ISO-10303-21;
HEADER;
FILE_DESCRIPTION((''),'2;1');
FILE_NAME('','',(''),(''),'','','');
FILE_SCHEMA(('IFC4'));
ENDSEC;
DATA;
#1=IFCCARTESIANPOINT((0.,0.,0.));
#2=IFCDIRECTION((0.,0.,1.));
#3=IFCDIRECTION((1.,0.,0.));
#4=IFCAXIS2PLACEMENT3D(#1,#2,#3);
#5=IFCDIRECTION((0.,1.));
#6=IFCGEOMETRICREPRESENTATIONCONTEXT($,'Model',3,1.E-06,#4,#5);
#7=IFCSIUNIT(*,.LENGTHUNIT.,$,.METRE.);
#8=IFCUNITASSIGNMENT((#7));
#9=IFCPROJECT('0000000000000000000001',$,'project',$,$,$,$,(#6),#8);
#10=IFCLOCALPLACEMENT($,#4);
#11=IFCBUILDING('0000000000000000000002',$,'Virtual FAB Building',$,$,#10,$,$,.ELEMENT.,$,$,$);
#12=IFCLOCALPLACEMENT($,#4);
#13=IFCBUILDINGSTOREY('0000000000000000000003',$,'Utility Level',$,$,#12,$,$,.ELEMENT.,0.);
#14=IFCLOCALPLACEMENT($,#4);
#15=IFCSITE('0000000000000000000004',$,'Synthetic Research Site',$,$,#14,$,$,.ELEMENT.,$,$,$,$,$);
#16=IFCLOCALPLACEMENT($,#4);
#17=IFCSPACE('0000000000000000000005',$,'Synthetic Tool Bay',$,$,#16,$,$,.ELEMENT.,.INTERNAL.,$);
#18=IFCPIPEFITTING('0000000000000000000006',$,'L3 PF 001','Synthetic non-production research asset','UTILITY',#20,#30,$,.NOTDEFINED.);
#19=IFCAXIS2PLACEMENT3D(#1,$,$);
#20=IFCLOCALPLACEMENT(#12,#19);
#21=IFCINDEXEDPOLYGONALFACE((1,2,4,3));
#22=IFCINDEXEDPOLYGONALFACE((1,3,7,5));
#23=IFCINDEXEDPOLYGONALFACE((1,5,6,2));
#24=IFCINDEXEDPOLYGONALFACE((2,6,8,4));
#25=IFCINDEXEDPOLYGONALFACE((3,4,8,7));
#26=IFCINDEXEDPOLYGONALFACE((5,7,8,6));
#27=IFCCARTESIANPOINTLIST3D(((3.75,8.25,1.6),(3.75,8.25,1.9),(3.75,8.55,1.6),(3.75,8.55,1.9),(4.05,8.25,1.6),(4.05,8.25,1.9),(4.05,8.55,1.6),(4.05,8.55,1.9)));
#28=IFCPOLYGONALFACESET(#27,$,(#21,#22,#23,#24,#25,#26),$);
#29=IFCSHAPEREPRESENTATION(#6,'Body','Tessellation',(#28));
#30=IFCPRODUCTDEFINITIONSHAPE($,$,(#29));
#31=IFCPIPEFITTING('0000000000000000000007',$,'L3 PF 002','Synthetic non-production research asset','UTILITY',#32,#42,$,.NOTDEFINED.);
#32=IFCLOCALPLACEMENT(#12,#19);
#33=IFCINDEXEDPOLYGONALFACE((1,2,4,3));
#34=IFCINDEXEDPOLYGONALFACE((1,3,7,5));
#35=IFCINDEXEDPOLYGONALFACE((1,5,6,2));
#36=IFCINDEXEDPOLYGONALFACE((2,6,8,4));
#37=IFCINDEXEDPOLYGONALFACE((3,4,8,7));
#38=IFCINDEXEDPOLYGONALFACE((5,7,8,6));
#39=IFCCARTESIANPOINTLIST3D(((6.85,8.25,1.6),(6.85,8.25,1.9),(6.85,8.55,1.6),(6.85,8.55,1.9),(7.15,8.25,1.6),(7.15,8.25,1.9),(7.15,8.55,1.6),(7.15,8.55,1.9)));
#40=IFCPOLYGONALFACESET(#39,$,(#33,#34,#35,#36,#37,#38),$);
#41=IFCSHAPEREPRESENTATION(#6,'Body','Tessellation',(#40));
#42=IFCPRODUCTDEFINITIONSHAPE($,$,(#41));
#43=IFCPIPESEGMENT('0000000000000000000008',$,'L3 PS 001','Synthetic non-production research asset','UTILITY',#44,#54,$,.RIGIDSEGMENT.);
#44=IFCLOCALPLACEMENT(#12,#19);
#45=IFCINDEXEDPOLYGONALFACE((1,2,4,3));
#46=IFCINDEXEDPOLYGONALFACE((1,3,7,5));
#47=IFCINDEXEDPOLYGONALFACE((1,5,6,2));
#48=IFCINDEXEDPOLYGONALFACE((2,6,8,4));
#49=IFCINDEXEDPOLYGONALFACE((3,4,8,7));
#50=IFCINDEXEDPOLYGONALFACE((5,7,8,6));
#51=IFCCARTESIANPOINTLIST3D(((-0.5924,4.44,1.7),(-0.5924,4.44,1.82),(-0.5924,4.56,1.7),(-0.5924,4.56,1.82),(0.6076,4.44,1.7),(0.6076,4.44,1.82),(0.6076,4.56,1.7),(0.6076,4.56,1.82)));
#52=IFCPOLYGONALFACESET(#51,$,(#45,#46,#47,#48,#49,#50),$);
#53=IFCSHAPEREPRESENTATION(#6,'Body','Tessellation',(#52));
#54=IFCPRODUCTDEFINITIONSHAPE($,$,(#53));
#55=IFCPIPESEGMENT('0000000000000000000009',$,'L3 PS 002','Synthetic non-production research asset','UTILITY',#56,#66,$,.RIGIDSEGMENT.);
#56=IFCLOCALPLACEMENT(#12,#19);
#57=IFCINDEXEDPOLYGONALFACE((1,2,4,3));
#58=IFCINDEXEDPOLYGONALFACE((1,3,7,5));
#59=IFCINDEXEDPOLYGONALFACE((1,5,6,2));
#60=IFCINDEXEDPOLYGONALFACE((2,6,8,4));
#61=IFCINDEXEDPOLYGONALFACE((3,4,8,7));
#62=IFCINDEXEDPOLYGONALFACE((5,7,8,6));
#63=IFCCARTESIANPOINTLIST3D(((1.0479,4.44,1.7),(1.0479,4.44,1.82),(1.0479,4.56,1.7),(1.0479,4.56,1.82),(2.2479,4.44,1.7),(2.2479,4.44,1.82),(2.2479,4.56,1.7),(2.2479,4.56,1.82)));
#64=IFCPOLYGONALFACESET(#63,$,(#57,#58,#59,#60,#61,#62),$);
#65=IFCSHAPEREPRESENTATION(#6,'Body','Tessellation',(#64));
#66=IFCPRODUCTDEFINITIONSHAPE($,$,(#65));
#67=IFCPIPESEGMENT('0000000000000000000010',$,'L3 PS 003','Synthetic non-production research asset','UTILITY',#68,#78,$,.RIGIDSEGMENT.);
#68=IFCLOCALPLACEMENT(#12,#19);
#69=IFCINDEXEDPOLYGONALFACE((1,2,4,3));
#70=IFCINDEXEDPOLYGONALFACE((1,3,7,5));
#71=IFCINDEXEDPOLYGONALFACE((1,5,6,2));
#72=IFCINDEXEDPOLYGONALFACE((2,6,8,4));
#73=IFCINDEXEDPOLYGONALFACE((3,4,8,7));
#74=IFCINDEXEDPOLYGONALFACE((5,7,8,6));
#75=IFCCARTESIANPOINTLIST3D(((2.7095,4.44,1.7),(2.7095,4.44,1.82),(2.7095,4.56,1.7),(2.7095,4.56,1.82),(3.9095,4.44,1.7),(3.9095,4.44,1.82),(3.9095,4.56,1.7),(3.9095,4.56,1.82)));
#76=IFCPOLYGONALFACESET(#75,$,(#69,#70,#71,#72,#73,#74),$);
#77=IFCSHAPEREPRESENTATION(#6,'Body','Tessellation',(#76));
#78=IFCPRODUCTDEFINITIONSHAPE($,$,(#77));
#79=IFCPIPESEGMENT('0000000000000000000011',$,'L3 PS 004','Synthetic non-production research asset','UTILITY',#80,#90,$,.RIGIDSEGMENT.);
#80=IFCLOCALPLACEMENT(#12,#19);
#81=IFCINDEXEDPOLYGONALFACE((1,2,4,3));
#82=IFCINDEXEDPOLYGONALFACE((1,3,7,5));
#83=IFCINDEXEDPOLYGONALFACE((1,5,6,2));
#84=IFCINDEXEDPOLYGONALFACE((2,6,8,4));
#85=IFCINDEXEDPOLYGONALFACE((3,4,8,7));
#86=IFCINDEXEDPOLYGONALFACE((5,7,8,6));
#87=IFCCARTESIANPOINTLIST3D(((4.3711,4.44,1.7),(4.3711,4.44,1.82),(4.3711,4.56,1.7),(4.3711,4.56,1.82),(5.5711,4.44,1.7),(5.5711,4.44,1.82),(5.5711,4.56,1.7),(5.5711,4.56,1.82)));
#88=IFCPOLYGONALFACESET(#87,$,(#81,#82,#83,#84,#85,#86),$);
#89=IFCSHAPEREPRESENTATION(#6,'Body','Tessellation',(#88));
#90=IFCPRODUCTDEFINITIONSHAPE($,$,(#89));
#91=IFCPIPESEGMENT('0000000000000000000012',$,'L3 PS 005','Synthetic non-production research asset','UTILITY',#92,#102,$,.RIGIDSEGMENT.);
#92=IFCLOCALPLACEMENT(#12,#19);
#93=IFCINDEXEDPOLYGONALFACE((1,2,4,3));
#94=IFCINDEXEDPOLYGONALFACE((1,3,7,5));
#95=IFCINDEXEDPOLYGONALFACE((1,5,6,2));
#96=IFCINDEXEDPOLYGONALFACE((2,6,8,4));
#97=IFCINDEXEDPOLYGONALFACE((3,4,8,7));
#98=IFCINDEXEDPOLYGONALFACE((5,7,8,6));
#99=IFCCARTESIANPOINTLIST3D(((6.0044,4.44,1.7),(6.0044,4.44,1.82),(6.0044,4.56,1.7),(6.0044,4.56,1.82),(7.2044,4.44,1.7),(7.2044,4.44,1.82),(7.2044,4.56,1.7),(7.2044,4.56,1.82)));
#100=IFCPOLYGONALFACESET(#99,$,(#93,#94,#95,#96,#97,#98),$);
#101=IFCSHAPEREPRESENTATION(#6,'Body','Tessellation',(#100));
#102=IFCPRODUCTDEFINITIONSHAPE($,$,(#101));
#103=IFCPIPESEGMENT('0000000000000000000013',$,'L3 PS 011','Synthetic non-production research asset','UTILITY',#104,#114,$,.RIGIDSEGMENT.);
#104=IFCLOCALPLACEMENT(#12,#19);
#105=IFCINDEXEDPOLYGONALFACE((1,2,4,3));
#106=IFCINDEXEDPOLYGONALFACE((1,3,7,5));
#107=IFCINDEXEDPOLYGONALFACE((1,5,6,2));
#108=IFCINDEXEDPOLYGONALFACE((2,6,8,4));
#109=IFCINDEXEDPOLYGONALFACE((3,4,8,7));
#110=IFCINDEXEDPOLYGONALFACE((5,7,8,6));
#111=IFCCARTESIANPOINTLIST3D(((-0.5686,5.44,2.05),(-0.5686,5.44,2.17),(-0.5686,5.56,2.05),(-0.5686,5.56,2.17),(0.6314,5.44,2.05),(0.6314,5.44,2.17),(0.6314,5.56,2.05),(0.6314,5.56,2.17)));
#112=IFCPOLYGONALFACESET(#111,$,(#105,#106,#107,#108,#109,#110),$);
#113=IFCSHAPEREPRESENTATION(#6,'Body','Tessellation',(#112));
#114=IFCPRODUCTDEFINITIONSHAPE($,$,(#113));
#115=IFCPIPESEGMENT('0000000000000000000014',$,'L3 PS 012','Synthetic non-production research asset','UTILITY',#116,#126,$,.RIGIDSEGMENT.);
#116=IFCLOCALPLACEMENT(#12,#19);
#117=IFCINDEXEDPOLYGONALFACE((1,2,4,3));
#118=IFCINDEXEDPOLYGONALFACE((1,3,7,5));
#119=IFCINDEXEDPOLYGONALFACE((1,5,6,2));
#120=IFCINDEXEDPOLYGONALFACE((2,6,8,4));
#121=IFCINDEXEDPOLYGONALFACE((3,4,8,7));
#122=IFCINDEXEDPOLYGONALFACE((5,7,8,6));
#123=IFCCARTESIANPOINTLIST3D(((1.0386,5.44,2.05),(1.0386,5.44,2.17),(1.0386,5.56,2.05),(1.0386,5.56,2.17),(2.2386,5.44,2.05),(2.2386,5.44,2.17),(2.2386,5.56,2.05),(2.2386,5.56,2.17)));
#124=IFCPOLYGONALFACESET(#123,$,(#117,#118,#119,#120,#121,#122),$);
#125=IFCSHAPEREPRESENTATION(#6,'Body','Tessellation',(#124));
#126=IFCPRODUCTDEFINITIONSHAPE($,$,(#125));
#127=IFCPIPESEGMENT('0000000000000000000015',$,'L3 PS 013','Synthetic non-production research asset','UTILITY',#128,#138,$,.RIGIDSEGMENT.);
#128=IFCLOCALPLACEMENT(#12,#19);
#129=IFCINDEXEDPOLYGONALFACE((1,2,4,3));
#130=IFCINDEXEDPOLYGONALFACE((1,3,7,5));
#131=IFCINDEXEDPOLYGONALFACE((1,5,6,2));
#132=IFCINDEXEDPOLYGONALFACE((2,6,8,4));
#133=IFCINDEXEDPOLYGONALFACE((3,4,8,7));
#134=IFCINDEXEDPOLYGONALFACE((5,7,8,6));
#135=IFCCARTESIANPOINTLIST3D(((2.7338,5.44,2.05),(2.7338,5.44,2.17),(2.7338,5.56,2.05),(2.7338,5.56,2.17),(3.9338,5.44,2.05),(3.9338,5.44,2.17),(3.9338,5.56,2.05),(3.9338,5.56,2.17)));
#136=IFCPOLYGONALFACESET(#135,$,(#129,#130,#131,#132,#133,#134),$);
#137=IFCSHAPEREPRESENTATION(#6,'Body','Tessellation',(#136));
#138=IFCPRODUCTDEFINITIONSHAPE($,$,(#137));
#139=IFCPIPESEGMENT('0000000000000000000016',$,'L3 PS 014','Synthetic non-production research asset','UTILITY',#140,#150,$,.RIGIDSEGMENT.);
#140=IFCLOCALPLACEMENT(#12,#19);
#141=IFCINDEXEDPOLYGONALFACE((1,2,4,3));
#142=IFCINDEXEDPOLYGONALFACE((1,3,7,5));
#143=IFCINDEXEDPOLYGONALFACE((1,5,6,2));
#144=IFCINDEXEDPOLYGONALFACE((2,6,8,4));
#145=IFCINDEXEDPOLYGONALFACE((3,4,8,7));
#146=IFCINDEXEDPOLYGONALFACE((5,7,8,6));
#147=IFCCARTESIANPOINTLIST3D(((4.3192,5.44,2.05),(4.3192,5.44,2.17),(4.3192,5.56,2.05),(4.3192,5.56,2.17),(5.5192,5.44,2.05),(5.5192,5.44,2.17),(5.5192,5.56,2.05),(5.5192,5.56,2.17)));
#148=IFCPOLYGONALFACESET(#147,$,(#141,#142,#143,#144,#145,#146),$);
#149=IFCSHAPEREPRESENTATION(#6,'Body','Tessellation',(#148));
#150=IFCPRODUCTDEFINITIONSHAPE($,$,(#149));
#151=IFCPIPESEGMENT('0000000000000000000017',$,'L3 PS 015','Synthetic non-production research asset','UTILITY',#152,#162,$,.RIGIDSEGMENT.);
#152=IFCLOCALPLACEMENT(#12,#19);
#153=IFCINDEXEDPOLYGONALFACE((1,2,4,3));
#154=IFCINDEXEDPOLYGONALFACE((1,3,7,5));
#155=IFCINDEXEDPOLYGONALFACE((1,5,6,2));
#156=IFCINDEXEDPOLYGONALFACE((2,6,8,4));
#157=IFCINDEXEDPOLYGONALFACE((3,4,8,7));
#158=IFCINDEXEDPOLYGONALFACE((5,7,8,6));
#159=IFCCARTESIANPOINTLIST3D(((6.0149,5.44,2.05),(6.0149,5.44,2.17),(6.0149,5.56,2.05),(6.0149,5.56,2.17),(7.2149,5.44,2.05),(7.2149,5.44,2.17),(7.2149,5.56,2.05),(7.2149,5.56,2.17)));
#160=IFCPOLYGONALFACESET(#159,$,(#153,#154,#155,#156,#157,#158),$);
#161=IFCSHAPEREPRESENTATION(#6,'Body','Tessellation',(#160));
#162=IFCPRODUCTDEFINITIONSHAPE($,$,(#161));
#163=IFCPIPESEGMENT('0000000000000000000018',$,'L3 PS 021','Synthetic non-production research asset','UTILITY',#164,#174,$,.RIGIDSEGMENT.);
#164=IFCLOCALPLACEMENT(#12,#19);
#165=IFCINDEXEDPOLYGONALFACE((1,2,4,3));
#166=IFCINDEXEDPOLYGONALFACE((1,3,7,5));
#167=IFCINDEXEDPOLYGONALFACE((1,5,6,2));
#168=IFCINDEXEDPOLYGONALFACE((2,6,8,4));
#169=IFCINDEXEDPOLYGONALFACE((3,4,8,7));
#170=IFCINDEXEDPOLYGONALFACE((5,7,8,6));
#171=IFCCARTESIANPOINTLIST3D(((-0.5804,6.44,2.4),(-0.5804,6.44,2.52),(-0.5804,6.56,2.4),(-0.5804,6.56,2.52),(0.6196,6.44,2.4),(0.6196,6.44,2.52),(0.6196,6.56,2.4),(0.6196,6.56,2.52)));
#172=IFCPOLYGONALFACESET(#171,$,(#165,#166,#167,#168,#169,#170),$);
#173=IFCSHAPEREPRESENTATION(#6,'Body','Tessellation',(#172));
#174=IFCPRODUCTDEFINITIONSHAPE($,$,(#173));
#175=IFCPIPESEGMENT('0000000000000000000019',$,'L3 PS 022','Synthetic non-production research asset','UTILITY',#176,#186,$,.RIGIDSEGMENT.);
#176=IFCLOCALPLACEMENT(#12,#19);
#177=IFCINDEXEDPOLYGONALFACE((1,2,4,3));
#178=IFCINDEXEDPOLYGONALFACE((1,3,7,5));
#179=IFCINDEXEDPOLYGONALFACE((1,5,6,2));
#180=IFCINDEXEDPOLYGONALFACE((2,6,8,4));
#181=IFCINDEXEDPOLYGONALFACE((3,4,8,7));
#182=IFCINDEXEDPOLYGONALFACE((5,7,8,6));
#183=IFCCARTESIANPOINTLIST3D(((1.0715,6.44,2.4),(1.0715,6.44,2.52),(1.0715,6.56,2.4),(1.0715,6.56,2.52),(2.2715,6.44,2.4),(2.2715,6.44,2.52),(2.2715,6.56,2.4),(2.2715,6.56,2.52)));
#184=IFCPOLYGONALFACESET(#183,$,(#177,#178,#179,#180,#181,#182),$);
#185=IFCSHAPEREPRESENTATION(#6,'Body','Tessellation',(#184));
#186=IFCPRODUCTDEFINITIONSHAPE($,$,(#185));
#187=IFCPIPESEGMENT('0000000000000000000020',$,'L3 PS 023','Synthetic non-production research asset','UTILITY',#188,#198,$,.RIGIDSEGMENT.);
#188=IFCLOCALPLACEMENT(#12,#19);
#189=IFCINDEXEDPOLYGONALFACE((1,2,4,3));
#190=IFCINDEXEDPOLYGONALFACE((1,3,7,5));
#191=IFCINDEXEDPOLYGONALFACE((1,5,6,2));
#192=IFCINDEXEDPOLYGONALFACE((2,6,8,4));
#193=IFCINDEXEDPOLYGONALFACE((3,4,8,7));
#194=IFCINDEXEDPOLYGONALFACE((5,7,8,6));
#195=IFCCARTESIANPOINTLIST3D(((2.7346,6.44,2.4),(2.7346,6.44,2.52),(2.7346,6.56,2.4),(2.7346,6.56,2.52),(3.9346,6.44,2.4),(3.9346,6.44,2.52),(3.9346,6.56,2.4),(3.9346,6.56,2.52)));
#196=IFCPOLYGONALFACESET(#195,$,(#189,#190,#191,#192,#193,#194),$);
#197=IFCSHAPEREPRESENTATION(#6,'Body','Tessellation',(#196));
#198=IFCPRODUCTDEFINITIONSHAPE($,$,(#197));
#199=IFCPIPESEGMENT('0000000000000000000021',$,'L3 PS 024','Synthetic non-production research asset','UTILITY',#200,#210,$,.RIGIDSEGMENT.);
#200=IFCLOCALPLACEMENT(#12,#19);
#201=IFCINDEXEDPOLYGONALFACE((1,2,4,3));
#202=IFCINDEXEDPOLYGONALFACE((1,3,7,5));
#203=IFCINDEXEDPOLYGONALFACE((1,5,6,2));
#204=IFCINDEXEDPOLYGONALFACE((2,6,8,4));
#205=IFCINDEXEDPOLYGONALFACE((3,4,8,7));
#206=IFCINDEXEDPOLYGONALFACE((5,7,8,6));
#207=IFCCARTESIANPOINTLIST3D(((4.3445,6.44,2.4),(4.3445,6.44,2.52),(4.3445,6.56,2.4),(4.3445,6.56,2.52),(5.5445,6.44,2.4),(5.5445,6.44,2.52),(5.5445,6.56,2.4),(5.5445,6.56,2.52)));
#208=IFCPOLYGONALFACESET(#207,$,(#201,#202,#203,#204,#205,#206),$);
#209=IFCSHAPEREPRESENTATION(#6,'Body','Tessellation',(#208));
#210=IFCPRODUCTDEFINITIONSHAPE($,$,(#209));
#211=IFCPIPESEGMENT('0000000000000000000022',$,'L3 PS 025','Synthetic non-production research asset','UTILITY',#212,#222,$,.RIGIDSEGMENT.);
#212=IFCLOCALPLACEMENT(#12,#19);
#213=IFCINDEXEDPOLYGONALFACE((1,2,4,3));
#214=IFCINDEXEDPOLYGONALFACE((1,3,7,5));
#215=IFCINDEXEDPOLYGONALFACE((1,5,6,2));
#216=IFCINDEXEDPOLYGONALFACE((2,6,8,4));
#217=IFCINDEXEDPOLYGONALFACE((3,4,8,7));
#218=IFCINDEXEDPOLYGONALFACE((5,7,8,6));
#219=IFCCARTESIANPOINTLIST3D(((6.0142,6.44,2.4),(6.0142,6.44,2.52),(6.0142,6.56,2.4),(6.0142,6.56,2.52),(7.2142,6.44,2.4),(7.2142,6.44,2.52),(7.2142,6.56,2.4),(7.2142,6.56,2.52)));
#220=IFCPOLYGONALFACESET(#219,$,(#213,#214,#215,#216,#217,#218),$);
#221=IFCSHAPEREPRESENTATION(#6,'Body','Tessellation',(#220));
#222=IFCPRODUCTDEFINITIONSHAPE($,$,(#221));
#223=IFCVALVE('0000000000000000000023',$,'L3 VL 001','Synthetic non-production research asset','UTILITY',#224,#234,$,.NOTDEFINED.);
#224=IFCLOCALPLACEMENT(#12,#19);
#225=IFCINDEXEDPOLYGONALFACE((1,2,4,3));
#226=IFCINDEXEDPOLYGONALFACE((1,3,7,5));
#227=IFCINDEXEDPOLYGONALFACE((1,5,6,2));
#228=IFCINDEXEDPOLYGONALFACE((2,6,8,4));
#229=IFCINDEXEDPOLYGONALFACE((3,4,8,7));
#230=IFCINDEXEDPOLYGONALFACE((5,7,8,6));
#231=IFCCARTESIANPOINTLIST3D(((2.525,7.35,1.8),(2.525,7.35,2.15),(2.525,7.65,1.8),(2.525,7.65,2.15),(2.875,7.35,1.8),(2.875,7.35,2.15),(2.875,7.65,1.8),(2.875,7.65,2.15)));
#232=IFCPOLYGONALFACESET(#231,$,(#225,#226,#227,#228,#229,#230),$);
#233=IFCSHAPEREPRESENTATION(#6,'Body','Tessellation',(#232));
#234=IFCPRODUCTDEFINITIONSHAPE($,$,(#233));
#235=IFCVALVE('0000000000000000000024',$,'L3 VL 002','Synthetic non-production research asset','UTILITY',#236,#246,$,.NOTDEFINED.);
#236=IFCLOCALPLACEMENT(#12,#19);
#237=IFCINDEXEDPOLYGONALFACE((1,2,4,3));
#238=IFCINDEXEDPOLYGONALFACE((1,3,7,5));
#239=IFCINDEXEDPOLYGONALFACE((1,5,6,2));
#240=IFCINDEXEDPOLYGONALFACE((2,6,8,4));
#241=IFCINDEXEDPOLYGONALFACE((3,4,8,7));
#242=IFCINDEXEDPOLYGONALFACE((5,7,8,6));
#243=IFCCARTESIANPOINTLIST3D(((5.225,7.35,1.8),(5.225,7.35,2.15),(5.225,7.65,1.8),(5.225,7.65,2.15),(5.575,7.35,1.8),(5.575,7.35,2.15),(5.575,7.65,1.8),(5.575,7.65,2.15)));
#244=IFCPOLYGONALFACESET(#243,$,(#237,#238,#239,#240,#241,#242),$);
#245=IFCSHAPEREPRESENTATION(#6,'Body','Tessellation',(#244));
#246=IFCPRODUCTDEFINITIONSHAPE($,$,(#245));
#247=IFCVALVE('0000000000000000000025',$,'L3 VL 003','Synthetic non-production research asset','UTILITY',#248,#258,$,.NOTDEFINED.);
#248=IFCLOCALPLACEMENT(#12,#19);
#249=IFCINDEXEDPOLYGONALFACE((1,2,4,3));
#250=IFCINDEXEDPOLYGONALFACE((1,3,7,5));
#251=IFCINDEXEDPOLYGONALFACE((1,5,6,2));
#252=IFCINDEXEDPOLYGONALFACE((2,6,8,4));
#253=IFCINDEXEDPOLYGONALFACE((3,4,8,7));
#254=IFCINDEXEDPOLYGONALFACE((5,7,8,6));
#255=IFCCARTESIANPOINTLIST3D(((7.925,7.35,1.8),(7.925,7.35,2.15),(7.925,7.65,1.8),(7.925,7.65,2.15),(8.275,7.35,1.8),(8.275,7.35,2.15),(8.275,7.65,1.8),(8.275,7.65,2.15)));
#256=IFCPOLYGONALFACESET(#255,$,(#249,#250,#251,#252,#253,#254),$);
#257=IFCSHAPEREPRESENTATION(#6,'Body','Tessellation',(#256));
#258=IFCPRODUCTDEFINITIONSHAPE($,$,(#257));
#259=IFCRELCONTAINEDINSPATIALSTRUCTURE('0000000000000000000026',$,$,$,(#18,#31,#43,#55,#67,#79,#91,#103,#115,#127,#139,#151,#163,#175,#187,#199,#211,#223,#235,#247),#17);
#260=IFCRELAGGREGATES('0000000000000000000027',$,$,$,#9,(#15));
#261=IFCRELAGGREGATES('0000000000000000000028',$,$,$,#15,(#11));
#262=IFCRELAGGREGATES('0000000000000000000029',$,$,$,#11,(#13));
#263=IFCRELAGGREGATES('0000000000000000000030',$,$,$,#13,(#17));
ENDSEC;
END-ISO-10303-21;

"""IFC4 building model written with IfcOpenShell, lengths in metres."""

from ifc_helpers import new_model, si_unit, direction, frame, origin_with_axes, origin_2d_with_axis, place, context, project, spatial, rectangle, extrude, element, save


model = new_model("IFC4")

# Units and contexts
model_context = context("Model", 3, precision=1e-06, world=origin_with_axes(), true_north=direction((0.0, 1.0)))
ifc_project = project(units=[si_unit("LENGTHUNIT", "METRE")], contexts=[model_context])

# Site, building, storey, space
site_placement = place(None, origin_with_axes())
site = spatial("IfcSite", under=ifc_project, at=site_placement, Name="Synthetic Research Site", CompositionType="ELEMENT")
building_placement = place(None, origin_with_axes())
building = spatial("IfcBuilding", under=site, at=building_placement, Name="Virtual FAB Building", CompositionType="ELEMENT")
storey_placement = place(None, origin_with_axes())
storey = spatial("IfcBuildingStorey", under=building, at=storey_placement, Name="Utility Level", CompositionType="ELEMENT", Elevation=0.0)
space_placement = place(None, origin_with_axes())
space = spatial("IfcSpace", under=storey, at=space_placement, Name="Synthetic Tool Bay", CompositionType="ELEMENT", PredefinedType="INTERNAL")

# Pipe fittings
for number, where, z_axis, x_axis, name in (
    (1, (3.9, 8.4, 1.6), (0.0, 0.0, 1.0), (1.0, 0.0, 0.0), "L3 PF 001"),
    (2, (7.0, 8.4, 1.6), (0.0, 0.0, 1.0), (1.0, 0.0, 0.0), "L3 PF 002"),
):
    element("IfcPipeFitting", number, at=place(None, frame(where, z_axis=z_axis, x_axis=x_axis)), inside=space, Name=name, Description="Synthetic non-production research asset", ObjectType="UTILITY", PredefinedType="NOTDEFINED", context=model_context, shape_type="SweptSolid", body=[
        extrude(rectangle(XDim=0.3, YDim=0.3, at=origin_2d_with_axis()), origin_with_axes(), (0.0, 0.0, 1.0), 0.3),
    ])

# Pipe segments
for number, where, z_axis, x_axis, name in (
    (3, (0.0076, 4.5, 1.7), (0.0, 0.0, 1.0), (1.0, 0.0, 0.0), "L3 PS 001"),
    (4, (1.6479, 4.5, 1.7), (0.0, 0.0, 1.0), (1.0, 0.0, 0.0), "L3 PS 002"),
    (5, (3.3095, 4.5, 1.7), (0.0, 0.0, 1.0), (1.0, 0.0, 0.0), "L3 PS 003"),
    (6, (4.9711, 4.5, 1.7), (0.0, 0.0, 1.0), (1.0, 0.0, 0.0), "L3 PS 004"),
    (7, (6.6044, 4.5, 1.7), (0.0, 0.0, 1.0), (1.0, 0.0, 0.0), "L3 PS 005"),
    (8, (0.0314, 5.5, 2.05), (0.0, 0.0, 1.0), (1.0, 0.0, 0.0), "L3 PS 011"),
    (9, (1.6386, 5.5, 2.05), (0.0, 0.0, 1.0), (1.0, 0.0, 0.0), "L3 PS 012"),
    (10, (3.3338, 5.5, 2.05), (0.0, 0.0, 1.0), (1.0, 0.0, 0.0), "L3 PS 013"),
    (11, (4.9192, 5.5, 2.05), (0.0, 0.0, 1.0), (1.0, 0.0, 0.0), "L3 PS 014"),
    (12, (6.6149, 5.5, 2.05), (0.0, 0.0, 1.0), (1.0, 0.0, 0.0), "L3 PS 015"),
    (13, (0.0196, 6.5, 2.4), (0.0, 0.0, 1.0), (1.0, 0.0, 0.0), "L3 PS 021"),
    (14, (1.6715, 6.5, 2.4), (0.0, 0.0, 1.0), (1.0, 0.0, 0.0), "L3 PS 022"),
    (15, (3.3346, 6.5, 2.4), (0.0, 0.0, 1.0), (1.0, 0.0, 0.0), "L3 PS 023"),
    (16, (4.9445, 6.5, 2.4), (0.0, 0.0, 1.0), (1.0, 0.0, 0.0), "L3 PS 024"),
    (17, (6.6142, 6.5, 2.4), (0.0, 0.0, 1.0), (1.0, 0.0, 0.0), "L3 PS 025"),
):
    element("IfcPipeSegment", number, at=place(None, frame(where, z_axis=z_axis, x_axis=x_axis)), inside=space, Name=name, Description="Synthetic non-production research asset", ObjectType="UTILITY", PredefinedType="RIGIDSEGMENT", context=model_context, shape_type="SweptSolid", body=[
        extrude(rectangle(XDim=1.2, YDim=0.12, at=origin_2d_with_axis()), origin_with_axes(), (0.0, 0.0, 1.0), 0.12),
    ])

# Valves
for number, where, z_axis, x_axis, name in (
    (18, (2.7, 7.5, 1.8), (0.0, 0.0, 1.0), (1.0, 0.0, 0.0), "L3 VL 001"),
    (19, (5.4, 7.5, 1.8), (0.0, 0.0, 1.0), (1.0, 0.0, 0.0), "L3 VL 002"),
    (20, (8.1, 7.5, 1.8), (0.0, 0.0, 1.0), (1.0, 0.0, 0.0), "L3 VL 003"),
):
    element("IfcValve", number, at=place(None, frame(where, z_axis=z_axis, x_axis=x_axis)), inside=space, Name=name, Description="Synthetic non-production research asset", ObjectType="UTILITY", PredefinedType="NOTDEFINED", context=model_context, shape_type="SweptSolid", body=[
        extrude(rectangle(XDim=0.35, YDim=0.3, at=origin_2d_with_axis()), origin_with_axes(), (0.0, 0.0, 1.0), 0.35),
    ])

save(model, "model.ifc")
